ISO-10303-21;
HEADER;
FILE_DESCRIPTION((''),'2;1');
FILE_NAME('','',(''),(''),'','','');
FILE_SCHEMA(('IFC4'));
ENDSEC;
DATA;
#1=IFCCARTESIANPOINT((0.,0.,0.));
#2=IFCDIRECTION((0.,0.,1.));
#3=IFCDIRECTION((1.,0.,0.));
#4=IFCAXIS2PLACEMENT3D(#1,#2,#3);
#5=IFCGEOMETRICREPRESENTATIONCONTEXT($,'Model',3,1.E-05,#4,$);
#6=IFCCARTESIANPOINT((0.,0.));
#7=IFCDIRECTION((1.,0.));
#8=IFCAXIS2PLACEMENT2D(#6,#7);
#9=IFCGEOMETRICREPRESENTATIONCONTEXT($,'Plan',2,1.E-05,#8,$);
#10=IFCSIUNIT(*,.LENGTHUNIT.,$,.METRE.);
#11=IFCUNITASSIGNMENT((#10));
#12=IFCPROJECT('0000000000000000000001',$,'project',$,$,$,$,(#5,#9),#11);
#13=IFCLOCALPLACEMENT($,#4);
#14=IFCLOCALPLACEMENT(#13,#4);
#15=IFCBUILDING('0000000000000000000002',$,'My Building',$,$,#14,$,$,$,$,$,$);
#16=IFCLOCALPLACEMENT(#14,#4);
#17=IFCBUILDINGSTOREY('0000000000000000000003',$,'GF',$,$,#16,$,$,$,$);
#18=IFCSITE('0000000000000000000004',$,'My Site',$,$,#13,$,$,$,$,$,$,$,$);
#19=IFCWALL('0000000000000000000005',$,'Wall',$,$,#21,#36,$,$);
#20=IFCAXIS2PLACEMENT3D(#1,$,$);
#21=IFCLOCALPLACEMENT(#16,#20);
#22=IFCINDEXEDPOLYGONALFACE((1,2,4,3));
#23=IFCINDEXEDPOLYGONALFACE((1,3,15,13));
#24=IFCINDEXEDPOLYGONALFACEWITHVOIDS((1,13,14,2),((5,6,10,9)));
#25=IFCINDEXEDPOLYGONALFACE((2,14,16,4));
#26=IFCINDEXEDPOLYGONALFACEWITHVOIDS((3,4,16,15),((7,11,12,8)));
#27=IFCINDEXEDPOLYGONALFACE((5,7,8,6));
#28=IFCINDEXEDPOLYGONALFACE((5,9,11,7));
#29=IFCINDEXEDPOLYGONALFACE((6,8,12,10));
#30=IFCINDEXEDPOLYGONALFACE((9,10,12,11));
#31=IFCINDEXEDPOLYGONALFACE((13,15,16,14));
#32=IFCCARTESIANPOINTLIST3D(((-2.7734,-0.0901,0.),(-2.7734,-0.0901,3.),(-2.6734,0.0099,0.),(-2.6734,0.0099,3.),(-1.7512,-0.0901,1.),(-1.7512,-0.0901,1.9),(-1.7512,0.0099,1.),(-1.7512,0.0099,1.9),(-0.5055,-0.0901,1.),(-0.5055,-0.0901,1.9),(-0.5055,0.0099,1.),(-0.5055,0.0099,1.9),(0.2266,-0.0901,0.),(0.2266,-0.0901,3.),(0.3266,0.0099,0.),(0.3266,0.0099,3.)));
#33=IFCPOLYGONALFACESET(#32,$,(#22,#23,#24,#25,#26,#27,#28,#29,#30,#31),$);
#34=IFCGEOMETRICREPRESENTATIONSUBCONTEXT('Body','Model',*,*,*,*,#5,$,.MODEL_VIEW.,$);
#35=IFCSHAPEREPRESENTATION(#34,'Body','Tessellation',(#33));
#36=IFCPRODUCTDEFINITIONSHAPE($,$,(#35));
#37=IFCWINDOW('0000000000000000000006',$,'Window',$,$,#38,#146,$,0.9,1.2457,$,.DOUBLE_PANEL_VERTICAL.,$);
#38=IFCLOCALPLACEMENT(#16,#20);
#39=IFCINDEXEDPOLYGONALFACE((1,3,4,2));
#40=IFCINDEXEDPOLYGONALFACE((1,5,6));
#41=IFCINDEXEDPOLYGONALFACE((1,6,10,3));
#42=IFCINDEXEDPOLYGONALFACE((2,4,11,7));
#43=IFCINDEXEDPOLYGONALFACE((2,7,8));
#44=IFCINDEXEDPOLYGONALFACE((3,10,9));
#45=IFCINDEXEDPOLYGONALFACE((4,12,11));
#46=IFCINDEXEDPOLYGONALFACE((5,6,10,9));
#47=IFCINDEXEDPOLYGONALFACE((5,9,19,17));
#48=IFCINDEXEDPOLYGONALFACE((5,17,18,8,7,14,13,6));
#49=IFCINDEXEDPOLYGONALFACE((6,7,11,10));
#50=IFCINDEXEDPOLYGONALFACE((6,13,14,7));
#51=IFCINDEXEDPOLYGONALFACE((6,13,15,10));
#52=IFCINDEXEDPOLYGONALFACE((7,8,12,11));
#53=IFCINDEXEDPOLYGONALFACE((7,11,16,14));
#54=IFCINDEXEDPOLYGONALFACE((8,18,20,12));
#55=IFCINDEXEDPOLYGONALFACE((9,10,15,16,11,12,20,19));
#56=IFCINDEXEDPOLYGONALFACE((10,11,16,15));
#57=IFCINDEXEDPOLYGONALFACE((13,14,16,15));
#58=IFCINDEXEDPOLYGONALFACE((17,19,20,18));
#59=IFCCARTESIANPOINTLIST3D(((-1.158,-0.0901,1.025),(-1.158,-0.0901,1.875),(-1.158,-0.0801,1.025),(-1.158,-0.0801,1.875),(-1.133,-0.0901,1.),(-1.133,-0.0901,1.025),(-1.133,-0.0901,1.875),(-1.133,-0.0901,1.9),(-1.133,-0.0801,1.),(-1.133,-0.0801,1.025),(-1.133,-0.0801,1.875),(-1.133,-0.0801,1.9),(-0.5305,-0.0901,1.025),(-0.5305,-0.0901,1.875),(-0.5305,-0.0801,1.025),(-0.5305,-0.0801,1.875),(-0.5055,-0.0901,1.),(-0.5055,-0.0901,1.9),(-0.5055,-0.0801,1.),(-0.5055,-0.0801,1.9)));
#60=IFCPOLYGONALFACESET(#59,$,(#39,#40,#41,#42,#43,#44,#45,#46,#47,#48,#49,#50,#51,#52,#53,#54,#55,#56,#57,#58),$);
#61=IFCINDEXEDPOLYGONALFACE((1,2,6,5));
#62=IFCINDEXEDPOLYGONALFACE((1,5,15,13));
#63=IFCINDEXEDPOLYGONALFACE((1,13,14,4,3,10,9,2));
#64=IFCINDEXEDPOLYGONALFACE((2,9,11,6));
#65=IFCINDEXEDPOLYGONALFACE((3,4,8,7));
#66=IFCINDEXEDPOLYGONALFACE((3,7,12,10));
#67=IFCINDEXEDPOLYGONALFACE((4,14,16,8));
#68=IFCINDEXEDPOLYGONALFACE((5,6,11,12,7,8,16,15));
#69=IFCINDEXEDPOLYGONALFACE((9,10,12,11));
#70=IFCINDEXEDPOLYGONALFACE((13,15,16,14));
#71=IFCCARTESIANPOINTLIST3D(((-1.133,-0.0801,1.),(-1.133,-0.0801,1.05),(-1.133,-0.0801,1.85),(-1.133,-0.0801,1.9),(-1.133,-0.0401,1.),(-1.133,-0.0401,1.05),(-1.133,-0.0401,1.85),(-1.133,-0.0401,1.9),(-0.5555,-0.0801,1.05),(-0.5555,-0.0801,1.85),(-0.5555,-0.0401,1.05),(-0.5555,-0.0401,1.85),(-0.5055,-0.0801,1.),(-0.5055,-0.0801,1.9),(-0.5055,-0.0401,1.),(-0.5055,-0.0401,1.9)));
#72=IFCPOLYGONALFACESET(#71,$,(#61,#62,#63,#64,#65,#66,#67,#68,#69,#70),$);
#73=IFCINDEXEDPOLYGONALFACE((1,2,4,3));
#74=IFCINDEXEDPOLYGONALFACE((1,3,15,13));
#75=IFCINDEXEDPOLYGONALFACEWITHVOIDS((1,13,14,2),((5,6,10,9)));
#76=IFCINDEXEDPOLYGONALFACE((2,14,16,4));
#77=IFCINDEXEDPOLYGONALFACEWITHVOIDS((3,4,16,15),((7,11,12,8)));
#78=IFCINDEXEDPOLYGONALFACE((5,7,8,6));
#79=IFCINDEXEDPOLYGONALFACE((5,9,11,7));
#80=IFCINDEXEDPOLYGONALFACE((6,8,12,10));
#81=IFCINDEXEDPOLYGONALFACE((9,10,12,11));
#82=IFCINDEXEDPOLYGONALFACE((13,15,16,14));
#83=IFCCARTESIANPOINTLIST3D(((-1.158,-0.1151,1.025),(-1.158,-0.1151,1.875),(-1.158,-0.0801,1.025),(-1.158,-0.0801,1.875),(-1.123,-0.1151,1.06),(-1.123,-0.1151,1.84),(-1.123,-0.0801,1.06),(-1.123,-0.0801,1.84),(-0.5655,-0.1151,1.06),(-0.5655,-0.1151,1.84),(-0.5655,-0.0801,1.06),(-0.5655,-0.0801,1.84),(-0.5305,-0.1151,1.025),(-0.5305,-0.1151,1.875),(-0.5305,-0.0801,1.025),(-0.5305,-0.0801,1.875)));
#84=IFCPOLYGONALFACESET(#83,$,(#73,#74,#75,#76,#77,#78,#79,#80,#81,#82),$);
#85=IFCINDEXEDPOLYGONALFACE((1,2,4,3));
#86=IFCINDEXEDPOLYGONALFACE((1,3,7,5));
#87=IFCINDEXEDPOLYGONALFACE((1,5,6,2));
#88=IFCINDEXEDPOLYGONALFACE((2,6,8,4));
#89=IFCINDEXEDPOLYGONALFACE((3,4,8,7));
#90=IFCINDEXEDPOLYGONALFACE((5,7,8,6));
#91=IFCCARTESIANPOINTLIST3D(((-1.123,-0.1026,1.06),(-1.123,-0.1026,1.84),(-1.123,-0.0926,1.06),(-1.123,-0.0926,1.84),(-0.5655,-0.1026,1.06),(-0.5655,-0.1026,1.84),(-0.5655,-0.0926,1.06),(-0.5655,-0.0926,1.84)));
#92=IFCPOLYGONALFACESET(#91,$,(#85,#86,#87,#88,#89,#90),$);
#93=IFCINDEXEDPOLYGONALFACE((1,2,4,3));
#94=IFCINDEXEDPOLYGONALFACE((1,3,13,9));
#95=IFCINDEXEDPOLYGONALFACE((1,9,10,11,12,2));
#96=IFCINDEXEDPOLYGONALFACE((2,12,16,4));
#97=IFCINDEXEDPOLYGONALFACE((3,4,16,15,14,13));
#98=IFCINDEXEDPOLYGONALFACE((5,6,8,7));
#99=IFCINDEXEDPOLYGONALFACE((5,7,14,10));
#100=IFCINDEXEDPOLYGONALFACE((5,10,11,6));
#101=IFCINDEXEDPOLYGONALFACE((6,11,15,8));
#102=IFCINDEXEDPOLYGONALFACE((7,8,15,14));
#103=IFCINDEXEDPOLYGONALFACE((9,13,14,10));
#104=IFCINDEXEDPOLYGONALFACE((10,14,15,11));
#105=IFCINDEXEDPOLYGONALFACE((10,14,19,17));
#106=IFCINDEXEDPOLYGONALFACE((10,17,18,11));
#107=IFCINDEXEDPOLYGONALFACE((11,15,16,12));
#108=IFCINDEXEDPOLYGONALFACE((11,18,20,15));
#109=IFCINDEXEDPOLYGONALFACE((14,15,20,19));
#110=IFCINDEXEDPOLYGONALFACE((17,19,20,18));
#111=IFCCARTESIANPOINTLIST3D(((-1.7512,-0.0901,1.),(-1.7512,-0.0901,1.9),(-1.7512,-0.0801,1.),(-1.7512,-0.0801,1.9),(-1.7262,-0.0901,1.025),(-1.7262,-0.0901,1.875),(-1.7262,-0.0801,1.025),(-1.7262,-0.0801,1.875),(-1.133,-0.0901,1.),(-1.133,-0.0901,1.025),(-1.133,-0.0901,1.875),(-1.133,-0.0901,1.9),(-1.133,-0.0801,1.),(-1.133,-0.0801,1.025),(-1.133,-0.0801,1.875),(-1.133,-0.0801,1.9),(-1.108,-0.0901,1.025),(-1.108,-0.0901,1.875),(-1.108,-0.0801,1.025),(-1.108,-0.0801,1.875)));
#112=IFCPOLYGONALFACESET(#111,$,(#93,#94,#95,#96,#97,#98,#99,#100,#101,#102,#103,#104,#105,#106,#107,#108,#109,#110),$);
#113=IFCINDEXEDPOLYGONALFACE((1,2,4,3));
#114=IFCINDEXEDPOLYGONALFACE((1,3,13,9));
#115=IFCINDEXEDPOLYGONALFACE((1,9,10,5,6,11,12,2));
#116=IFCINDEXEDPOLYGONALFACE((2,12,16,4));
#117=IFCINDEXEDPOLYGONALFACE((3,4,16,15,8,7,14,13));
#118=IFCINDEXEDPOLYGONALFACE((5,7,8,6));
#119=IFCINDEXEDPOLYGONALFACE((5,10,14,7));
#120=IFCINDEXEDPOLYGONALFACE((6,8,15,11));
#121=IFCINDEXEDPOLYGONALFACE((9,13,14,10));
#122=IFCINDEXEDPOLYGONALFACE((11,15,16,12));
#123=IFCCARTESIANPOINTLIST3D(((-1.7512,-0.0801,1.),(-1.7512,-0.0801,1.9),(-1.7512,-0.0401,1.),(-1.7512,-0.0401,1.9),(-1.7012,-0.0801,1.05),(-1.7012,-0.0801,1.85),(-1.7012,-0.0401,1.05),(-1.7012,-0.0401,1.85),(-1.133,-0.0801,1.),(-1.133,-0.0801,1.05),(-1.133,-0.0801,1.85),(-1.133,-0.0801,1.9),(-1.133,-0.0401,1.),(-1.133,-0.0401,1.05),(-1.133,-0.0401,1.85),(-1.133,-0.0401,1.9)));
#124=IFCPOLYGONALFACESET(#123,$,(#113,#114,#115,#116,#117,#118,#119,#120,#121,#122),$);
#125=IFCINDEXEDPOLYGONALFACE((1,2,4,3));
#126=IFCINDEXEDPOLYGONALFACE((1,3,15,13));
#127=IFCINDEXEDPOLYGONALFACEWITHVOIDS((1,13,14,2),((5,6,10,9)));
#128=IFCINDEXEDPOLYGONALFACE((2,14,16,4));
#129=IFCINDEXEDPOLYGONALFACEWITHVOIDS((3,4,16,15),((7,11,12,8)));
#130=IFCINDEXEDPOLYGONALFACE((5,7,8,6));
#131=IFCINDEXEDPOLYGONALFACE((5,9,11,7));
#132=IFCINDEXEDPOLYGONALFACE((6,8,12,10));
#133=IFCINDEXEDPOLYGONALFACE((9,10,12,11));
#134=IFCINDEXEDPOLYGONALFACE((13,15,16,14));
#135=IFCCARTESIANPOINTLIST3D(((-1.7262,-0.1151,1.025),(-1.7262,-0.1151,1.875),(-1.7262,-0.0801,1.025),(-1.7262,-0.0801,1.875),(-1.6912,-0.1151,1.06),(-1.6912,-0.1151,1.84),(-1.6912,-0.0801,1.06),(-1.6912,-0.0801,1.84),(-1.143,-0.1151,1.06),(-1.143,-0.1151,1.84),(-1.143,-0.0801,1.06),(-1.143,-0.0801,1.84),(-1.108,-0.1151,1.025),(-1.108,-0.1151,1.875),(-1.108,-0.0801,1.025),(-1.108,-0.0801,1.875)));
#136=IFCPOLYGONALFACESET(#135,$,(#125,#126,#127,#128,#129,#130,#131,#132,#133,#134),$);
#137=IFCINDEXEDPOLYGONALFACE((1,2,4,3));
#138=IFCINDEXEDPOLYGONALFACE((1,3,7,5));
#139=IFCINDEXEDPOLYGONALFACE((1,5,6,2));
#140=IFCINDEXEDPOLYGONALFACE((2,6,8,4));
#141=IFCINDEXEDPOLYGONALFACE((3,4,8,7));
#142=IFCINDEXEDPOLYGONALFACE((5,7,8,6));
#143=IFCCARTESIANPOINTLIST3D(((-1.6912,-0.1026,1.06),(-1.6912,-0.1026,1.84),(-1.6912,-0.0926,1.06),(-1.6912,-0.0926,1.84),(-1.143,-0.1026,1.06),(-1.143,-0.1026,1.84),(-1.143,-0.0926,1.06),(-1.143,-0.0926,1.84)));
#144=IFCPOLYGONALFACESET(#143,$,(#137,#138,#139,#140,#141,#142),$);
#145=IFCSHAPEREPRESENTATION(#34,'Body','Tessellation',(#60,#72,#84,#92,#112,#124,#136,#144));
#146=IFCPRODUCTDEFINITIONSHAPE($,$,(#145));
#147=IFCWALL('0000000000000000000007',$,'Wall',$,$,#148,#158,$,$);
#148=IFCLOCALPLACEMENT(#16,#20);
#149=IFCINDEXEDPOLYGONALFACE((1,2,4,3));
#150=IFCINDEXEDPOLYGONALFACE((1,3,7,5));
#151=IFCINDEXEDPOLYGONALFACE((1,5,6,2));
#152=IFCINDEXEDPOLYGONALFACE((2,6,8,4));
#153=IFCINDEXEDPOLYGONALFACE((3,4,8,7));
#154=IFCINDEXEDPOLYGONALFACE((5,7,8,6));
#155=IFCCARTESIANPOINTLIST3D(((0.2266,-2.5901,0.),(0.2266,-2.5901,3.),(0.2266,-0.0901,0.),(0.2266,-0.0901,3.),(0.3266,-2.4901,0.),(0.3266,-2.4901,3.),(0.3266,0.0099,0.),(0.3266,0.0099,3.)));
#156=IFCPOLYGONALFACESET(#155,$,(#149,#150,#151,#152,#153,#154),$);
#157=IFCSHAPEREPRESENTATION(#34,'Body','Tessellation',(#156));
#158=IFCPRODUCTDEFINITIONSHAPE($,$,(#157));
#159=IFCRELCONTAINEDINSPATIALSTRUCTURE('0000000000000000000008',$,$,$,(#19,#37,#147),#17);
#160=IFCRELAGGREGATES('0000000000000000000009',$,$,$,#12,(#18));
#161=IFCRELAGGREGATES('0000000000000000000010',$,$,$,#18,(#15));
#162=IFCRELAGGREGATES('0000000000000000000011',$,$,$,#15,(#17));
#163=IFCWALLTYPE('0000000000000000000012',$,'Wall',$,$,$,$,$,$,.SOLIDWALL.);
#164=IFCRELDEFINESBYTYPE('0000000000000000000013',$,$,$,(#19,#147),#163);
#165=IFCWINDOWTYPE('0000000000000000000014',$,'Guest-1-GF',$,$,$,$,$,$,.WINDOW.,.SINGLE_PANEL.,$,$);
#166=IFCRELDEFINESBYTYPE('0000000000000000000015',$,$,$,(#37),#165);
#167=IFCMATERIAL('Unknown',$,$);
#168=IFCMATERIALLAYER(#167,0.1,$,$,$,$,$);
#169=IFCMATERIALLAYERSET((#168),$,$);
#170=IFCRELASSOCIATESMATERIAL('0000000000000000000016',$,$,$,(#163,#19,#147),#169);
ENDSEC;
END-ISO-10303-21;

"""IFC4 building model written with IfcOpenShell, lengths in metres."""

from ifc_helpers import new_model, entity, si_unit, frame, origin_with_axes, origin_2d_with_axis, place, context, subcontext, project, spatial, line, indexed_curve, outline, extrude, shape, source, transform, mapped, material, layer, layer_set, layer_usage, type_object, type_shapes, element, fill, save


model = new_model("IFC4")

# Units and contexts
model_context = context("Model", 3, precision=1e-05, world=origin_with_axes())
plan_context = context("Plan", 2, precision=1e-05, world=origin_2d_with_axis())
body_context_1 = subcontext(model_context, "Body", "Model", "MODEL_VIEW")
body_context_2 = subcontext(plan_context, "Body", "Plan", "PLAN_VIEW")
ifc_project = project(units=[si_unit("LENGTHUNIT", "METRE")], contexts=[model_context, plan_context])

# Site, building, storey
site_placement = place(None, origin_with_axes())
site = spatial("IfcSite", under=ifc_project, at=site_placement, Name="My Site")
building_placement = place(site_placement, origin_with_axes())
building = spatial("IfcBuilding", under=site, at=building_placement, Name="My Building")
storey_placement = place(building_placement, origin_with_axes())
storey = spatial("IfcBuildingStorey", under=building, at=storey_placement, Name="GF")

# Shared definitions
ifc_material_1 = material(Name="Unknown")

# Shared definitions
ifc_layer_1 = layer(ifc_material_1, 0.1)
ifc_layer_set_1 = layer_set([ifc_layer_1])
wall_type = type_object("IfcWallType", Name="Wall", PredefinedType="SOLIDWALL", material=ifc_layer_set_1)

# Wall, opening, window
ifc_layer_usage_1 = layer_usage(ifc_layer_set_1, "AXIS2", "POSITIVE", 0.0)
wall_1_placement = place(storey_placement, frame((-2.7734, -0.0901, 0.0), z_axis=(0.0, 0.0, 1.0), x_axis=(1.0, 0.0, 0.0)))
wall_1 = element("IfcWall", 1, at=wall_1_placement, inside=storey, type_object=wall_type, material=ifc_layer_usage_1, Name="Wall", context=body_context_1, shape_type="SweptSolid", body=[
    extrude(outline(indexed_curve([(0.0, 0.0), (0.1, 0.1), (3.1, 0.1), (3.0, 0.0)], segments=[line(1, 2, 3, 4, 1)])), origin_with_axes(), (0.0, 0.0, 1.0), 3.0),
])
shared_shape_1 = source(origin_with_axes(), body_context_1, "Body", "SweptSolid", [
    extrude(outline(indexed_curve([(0.0, 0.0), (1.2457, 0.0), (1.2457, 0.9), (0.0, 0.9)], segments=[line(1, 2, 3, 4, 1)])), frame((0.0, -0.6, 0.0), z_axis=(0.0, -1.0, 0.0), x_axis=(1.0, 0.0, 0.0)), (0.0, 0.0, -1.0), 1.2),
])
opening_1_placement = place(wall_1_placement, frame((2.2679, 0.1, 1.0), z_axis=(0.0, 0.0, 1.0), x_axis=(-1.0, 0.000001, 0.0)))
opening_1 = element("IfcOpeningElement", 2, at=opening_1_placement, cuts=wall_1, PredefinedType="OPENING", context=body_context_1, shape_type="MappedRepresentation", body=[
    mapped(shared_shape_1, transform((0.0, 0.0, 0.0), x_axis=(1.0, 0.0, 0.0), y_axis=(0.0, 1.0, 0.0), z_axis=(0.0, 0.0, 1.0), scale=1.0)),
])
window_type_1 = type_object("IfcWindowType", Name="Guest-1-GF", PartitioningType="SINGLE_PANEL", PredefinedType="WINDOW")
shared_shape_2 = source(origin_with_axes(), body_context_1, "Body", "SweptSolid", [
    extrude(outline(indexed_curve([(0.0, 0.0), (0.6275, 0.0), (0.6275, 0.9), (0.0, 0.9)], segments=[line(1, 2, 3, 4, 1)]), holes=[indexed_curve([(0.025, 0.025), (0.6525, 0.025), (0.6525, 0.875), (0.025, 0.875)], segments=[line(1, 2, 3, 4, 1)])]), frame((0.0, 0.09, 0.0), z_axis=(0.0, -1.0, 0.0), x_axis=(1.0, 0.0, 0.0)), (0.0, 0.0, -1.0), 0.01),
    extrude(outline(indexed_curve([(0.6275, 0.0), (0.0, 0.0), (0.0, 0.9), (0.6275, 0.9), (0.6275, 0.85), (0.05, 0.85), (0.05, 0.05), (0.6275, 0.05)], segments=[line(1, 2, 3, 4, 5, 6, 7, 8, 1)])), frame((0.0, 0.05, 0.0), z_axis=(0.0, -1.0, 0.0), x_axis=(1.0, 0.0, 0.0)), (0.0, 0.0, -1.0), 0.04),
    extrude(outline(indexed_curve([(0.0, 0.0), (0.6275, 0.0), (0.6275, 0.85), (0.0, 0.85)], segments=[line(1, 2, 3, 4, 1)]), holes=[indexed_curve([(0.035, 0.035), (0.5925, 0.035), (0.5925, 0.815), (0.035, 0.815)], segments=[line(1, 2, 3, 4, 1)])]), frame((0.025, 0.09, 0.025), z_axis=(0.0, -1.0, 0.0), x_axis=(1.0, 0.0, 0.0)), (0.0, 0.0, -1.0), 0.035),
    extrude(outline(indexed_curve([(0.035, 0.035), (0.5925, 0.035), (0.5925, 0.815), (0.035, 0.815)], segments=[line(1, 2, 3, 4, 1)])), frame((0.025, 0.1025, 0.025), z_axis=(0.0, -1.0, 0.0), x_axis=(1.0, 0.0, 0.0)), (0.0, 0.0, -1.0), 0.01),
    extrude(outline(indexed_curve([(0.0, 0.0), (0.6181, 0.0), (0.6181, 0.9), (0.0, 0.9)], segments=[line(1, 2, 3, 4, 1)]), holes=[indexed_curve([(-0.025, 0.025), (0.5931, 0.025), (0.5931, 0.875), (-0.025, 0.875)], segments=[line(1, 2, 3, 4, 1)])]), frame((0.6275, 0.09, 0.0), z_axis=(0.0, -1.0, 0.0), x_axis=(1.0, 0.0, 0.0)), (0.0, 0.0, -1.0), 0.01),
    extrude(outline(indexed_curve([(0.0, 0.9), (0.6181, 0.9), (0.6181, 0.0), (0.0, 0.0), (0.0, 0.05), (0.5681, 0.05), (0.5681, 0.85), (0.0, 0.85)], segments=[line(1, 2, 3, 4, 5, 6, 7, 8, 1)])), frame((0.6275, 0.05, 0.0), z_axis=(0.0, -1.0, 0.0), x_axis=(1.0, 0.0, 0.0)), (0.0, 0.0, -1.0), 0.04),
    extrude(outline(indexed_curve([(0.0, 0.0), (0.6181, 0.0), (0.6181, 0.85), (0.0, 0.85)], segments=[line(1, 2, 3, 4, 1)]), holes=[indexed_curve([(0.035, 0.035), (0.5831, 0.035), (0.5831, 0.815), (0.035, 0.815)], segments=[line(1, 2, 3, 4, 1)])]), frame((0.6025, 0.09, 0.025), z_axis=(0.0, -1.0, 0.0), x_axis=(1.0, 0.0, 0.0)), (0.0, 0.0, -1.0), 0.035),
    extrude(outline(indexed_curve([(0.035, 0.035), (0.5831, 0.035), (0.5831, 0.815), (0.035, 0.815)], segments=[line(1, 2, 3, 4, 1)])), frame((0.6025, 0.1025, 0.025), z_axis=(0.0, -1.0, 0.0), x_axis=(1.0, 0.0, 0.0)), (0.0, 0.0, -1.0), 0.01),
])
shared_shape_3 = source(origin_with_axes(), body_context_2, "Body", "Curve2D", [
    entity("IfcIndexedPolyCurve", entity("IfcCartesianPointList2D", [[0.05, 0.05], [0.6275, 0.05]])),
    entity("IfcIndexedPolyCurve", entity("IfcCartesianPointList2D", [[0.0, 0.1], [0.025, 0.1], [0.025, 0.09], [0.05, 0.09], [0.05, 0.05], [0.0, 0.05]]), [entity("IfcLineIndex", [1, 2, 3, 4, 5, 6, 1])]),
    entity("IfcIndexedPolyCurve", entity("IfcCartesianPointList2D", [[0.6275, 0.1], [0.6525, 0.1], [0.6525, 0.09], [0.6275, 0.09], [0.6275, 0.05], [0.6275, 0.05]])),
    entity("IfcIndexedPolyCurve", entity("IfcCartesianPointList2D", [[0.025, 0.09], [0.06, 0.09], [0.06, 0.125], [0.025, 0.125]]), [entity("IfcLineIndex", [1, 2, 3, 4, 1])]),
    entity("IfcIndexedPolyCurve", entity("IfcCartesianPointList2D", [[0.6525, 0.09], [0.6175, 0.09], [0.6175, 0.125], [0.6525, 0.125]]), [entity("IfcLineIndex", [1, 2, 3, 4, 1])]),
    entity("IfcIndexedPolyCurve", entity("IfcCartesianPointList2D", [[0.06, 0.09], [0.6175, 0.09]])),
    entity("IfcIndexedPolyCurve", entity("IfcCartesianPointList2D", [[0.06, 0.125], [0.6175, 0.125]])),
    entity("IfcIndexedPolyCurve", entity("IfcCartesianPointList2D", [[0.06, 0.1075], [0.6175, 0.1075]])),
    entity("IfcIndexedPolyCurve", entity("IfcCartesianPointList2D", [[0.6275, 0.05], [1.1957, 0.05]])),
    entity("IfcIndexedPolyCurve", entity("IfcCartesianPointList2D", [[0.6275, 0.1], [0.6025, 0.1], [0.6025, 0.09], [0.6275, 0.09], [0.6275, 0.05], [0.6275, 0.05]])),
    entity("IfcIndexedPolyCurve", entity("IfcCartesianPointList2D", [[1.2457, 0.1], [1.2207, 0.1], [1.2207, 0.09], [1.1957, 0.09], [1.1957, 0.05], [1.2457, 0.05]]), [entity("IfcLineIndex", [1, 2, 3, 4, 5, 6, 1])]),
    entity("IfcIndexedPolyCurve", entity("IfcCartesianPointList2D", [[0.6025, 0.09], [0.6375, 0.09], [0.6375, 0.125], [0.6025, 0.125]]), [entity("IfcLineIndex", [1, 2, 3, 4, 1])]),
    entity("IfcIndexedPolyCurve", entity("IfcCartesianPointList2D", [[1.2207, 0.09], [1.1857, 0.09], [1.1857, 0.125], [1.2207, 0.125]]), [entity("IfcLineIndex", [1, 2, 3, 4, 1])]),
    entity("IfcIndexedPolyCurve", entity("IfcCartesianPointList2D", [[0.6375, 0.09], [1.1857, 0.09]])),
    entity("IfcIndexedPolyCurve", entity("IfcCartesianPointList2D", [[0.6375, 0.125], [1.1857, 0.125]])),
    entity("IfcIndexedPolyCurve", entity("IfcCartesianPointList2D", [[0.6375, 0.1075], [1.1857, 0.1075]])),
])
type_shapes(window_type_1, [shared_shape_2, shared_shape_3])
window_1_placement = place(opening_1_placement, origin_with_axes())
window_1 = element("IfcWindow", 3, at=window_1_placement, inside=storey, type_object=window_type_1, Name="Window", OverallHeight=0.9, OverallWidth=1.2457, PartitioningType="DOUBLE_PANEL_VERTICAL", shapes=[
    shape(body_context_1, "Body", "MappedRepresentation", [mapped(shared_shape_2, transform((0.0, 0.0, 0.0), x_axis=(1.0, 0.0, 0.0), y_axis=(0.0, 1.0, 0.0), z_axis=(0.0, 0.0, 1.0), scale=1.0))]),
    shape(body_context_2, "Body", "MappedRepresentation", [mapped(shared_shape_3, transform((0.0, 0.0, 0.0), x_axis=(1.0, 0.0, 0.0), y_axis=(0.0, 1.0, 0.0), z_axis=(0.0, 0.0, 1.0), scale=1.0))]),
])
fill(opening_1, window_1)

# Wall
ifc_layer_usage_2 = layer_usage(ifc_layer_set_1, "AXIS2", "POSITIVE", 0.0)
wall_2_placement = place(storey_placement, frame((0.2266, -0.0901, 0.0), z_axis=(0.0, 0.0, 1.0), x_axis=(-0.000001, -1.0, 0.0)))
element("IfcWall", 4, at=wall_2_placement, inside=storey, type_object=wall_type, material=ifc_layer_usage_2, Name="Wall", context=body_context_1, shape_type="SweptSolid", body=[
    extrude(outline(indexed_curve([(0.0, 0.0), (-0.1, 0.1), (2.4, 0.1), (2.5, 0.0)], segments=[line(1, 2, 3, 4, 1)])), origin_with_axes(), (0.0, 0.0, 1.0), 3.0),
])

save(model, "model.ifc")
